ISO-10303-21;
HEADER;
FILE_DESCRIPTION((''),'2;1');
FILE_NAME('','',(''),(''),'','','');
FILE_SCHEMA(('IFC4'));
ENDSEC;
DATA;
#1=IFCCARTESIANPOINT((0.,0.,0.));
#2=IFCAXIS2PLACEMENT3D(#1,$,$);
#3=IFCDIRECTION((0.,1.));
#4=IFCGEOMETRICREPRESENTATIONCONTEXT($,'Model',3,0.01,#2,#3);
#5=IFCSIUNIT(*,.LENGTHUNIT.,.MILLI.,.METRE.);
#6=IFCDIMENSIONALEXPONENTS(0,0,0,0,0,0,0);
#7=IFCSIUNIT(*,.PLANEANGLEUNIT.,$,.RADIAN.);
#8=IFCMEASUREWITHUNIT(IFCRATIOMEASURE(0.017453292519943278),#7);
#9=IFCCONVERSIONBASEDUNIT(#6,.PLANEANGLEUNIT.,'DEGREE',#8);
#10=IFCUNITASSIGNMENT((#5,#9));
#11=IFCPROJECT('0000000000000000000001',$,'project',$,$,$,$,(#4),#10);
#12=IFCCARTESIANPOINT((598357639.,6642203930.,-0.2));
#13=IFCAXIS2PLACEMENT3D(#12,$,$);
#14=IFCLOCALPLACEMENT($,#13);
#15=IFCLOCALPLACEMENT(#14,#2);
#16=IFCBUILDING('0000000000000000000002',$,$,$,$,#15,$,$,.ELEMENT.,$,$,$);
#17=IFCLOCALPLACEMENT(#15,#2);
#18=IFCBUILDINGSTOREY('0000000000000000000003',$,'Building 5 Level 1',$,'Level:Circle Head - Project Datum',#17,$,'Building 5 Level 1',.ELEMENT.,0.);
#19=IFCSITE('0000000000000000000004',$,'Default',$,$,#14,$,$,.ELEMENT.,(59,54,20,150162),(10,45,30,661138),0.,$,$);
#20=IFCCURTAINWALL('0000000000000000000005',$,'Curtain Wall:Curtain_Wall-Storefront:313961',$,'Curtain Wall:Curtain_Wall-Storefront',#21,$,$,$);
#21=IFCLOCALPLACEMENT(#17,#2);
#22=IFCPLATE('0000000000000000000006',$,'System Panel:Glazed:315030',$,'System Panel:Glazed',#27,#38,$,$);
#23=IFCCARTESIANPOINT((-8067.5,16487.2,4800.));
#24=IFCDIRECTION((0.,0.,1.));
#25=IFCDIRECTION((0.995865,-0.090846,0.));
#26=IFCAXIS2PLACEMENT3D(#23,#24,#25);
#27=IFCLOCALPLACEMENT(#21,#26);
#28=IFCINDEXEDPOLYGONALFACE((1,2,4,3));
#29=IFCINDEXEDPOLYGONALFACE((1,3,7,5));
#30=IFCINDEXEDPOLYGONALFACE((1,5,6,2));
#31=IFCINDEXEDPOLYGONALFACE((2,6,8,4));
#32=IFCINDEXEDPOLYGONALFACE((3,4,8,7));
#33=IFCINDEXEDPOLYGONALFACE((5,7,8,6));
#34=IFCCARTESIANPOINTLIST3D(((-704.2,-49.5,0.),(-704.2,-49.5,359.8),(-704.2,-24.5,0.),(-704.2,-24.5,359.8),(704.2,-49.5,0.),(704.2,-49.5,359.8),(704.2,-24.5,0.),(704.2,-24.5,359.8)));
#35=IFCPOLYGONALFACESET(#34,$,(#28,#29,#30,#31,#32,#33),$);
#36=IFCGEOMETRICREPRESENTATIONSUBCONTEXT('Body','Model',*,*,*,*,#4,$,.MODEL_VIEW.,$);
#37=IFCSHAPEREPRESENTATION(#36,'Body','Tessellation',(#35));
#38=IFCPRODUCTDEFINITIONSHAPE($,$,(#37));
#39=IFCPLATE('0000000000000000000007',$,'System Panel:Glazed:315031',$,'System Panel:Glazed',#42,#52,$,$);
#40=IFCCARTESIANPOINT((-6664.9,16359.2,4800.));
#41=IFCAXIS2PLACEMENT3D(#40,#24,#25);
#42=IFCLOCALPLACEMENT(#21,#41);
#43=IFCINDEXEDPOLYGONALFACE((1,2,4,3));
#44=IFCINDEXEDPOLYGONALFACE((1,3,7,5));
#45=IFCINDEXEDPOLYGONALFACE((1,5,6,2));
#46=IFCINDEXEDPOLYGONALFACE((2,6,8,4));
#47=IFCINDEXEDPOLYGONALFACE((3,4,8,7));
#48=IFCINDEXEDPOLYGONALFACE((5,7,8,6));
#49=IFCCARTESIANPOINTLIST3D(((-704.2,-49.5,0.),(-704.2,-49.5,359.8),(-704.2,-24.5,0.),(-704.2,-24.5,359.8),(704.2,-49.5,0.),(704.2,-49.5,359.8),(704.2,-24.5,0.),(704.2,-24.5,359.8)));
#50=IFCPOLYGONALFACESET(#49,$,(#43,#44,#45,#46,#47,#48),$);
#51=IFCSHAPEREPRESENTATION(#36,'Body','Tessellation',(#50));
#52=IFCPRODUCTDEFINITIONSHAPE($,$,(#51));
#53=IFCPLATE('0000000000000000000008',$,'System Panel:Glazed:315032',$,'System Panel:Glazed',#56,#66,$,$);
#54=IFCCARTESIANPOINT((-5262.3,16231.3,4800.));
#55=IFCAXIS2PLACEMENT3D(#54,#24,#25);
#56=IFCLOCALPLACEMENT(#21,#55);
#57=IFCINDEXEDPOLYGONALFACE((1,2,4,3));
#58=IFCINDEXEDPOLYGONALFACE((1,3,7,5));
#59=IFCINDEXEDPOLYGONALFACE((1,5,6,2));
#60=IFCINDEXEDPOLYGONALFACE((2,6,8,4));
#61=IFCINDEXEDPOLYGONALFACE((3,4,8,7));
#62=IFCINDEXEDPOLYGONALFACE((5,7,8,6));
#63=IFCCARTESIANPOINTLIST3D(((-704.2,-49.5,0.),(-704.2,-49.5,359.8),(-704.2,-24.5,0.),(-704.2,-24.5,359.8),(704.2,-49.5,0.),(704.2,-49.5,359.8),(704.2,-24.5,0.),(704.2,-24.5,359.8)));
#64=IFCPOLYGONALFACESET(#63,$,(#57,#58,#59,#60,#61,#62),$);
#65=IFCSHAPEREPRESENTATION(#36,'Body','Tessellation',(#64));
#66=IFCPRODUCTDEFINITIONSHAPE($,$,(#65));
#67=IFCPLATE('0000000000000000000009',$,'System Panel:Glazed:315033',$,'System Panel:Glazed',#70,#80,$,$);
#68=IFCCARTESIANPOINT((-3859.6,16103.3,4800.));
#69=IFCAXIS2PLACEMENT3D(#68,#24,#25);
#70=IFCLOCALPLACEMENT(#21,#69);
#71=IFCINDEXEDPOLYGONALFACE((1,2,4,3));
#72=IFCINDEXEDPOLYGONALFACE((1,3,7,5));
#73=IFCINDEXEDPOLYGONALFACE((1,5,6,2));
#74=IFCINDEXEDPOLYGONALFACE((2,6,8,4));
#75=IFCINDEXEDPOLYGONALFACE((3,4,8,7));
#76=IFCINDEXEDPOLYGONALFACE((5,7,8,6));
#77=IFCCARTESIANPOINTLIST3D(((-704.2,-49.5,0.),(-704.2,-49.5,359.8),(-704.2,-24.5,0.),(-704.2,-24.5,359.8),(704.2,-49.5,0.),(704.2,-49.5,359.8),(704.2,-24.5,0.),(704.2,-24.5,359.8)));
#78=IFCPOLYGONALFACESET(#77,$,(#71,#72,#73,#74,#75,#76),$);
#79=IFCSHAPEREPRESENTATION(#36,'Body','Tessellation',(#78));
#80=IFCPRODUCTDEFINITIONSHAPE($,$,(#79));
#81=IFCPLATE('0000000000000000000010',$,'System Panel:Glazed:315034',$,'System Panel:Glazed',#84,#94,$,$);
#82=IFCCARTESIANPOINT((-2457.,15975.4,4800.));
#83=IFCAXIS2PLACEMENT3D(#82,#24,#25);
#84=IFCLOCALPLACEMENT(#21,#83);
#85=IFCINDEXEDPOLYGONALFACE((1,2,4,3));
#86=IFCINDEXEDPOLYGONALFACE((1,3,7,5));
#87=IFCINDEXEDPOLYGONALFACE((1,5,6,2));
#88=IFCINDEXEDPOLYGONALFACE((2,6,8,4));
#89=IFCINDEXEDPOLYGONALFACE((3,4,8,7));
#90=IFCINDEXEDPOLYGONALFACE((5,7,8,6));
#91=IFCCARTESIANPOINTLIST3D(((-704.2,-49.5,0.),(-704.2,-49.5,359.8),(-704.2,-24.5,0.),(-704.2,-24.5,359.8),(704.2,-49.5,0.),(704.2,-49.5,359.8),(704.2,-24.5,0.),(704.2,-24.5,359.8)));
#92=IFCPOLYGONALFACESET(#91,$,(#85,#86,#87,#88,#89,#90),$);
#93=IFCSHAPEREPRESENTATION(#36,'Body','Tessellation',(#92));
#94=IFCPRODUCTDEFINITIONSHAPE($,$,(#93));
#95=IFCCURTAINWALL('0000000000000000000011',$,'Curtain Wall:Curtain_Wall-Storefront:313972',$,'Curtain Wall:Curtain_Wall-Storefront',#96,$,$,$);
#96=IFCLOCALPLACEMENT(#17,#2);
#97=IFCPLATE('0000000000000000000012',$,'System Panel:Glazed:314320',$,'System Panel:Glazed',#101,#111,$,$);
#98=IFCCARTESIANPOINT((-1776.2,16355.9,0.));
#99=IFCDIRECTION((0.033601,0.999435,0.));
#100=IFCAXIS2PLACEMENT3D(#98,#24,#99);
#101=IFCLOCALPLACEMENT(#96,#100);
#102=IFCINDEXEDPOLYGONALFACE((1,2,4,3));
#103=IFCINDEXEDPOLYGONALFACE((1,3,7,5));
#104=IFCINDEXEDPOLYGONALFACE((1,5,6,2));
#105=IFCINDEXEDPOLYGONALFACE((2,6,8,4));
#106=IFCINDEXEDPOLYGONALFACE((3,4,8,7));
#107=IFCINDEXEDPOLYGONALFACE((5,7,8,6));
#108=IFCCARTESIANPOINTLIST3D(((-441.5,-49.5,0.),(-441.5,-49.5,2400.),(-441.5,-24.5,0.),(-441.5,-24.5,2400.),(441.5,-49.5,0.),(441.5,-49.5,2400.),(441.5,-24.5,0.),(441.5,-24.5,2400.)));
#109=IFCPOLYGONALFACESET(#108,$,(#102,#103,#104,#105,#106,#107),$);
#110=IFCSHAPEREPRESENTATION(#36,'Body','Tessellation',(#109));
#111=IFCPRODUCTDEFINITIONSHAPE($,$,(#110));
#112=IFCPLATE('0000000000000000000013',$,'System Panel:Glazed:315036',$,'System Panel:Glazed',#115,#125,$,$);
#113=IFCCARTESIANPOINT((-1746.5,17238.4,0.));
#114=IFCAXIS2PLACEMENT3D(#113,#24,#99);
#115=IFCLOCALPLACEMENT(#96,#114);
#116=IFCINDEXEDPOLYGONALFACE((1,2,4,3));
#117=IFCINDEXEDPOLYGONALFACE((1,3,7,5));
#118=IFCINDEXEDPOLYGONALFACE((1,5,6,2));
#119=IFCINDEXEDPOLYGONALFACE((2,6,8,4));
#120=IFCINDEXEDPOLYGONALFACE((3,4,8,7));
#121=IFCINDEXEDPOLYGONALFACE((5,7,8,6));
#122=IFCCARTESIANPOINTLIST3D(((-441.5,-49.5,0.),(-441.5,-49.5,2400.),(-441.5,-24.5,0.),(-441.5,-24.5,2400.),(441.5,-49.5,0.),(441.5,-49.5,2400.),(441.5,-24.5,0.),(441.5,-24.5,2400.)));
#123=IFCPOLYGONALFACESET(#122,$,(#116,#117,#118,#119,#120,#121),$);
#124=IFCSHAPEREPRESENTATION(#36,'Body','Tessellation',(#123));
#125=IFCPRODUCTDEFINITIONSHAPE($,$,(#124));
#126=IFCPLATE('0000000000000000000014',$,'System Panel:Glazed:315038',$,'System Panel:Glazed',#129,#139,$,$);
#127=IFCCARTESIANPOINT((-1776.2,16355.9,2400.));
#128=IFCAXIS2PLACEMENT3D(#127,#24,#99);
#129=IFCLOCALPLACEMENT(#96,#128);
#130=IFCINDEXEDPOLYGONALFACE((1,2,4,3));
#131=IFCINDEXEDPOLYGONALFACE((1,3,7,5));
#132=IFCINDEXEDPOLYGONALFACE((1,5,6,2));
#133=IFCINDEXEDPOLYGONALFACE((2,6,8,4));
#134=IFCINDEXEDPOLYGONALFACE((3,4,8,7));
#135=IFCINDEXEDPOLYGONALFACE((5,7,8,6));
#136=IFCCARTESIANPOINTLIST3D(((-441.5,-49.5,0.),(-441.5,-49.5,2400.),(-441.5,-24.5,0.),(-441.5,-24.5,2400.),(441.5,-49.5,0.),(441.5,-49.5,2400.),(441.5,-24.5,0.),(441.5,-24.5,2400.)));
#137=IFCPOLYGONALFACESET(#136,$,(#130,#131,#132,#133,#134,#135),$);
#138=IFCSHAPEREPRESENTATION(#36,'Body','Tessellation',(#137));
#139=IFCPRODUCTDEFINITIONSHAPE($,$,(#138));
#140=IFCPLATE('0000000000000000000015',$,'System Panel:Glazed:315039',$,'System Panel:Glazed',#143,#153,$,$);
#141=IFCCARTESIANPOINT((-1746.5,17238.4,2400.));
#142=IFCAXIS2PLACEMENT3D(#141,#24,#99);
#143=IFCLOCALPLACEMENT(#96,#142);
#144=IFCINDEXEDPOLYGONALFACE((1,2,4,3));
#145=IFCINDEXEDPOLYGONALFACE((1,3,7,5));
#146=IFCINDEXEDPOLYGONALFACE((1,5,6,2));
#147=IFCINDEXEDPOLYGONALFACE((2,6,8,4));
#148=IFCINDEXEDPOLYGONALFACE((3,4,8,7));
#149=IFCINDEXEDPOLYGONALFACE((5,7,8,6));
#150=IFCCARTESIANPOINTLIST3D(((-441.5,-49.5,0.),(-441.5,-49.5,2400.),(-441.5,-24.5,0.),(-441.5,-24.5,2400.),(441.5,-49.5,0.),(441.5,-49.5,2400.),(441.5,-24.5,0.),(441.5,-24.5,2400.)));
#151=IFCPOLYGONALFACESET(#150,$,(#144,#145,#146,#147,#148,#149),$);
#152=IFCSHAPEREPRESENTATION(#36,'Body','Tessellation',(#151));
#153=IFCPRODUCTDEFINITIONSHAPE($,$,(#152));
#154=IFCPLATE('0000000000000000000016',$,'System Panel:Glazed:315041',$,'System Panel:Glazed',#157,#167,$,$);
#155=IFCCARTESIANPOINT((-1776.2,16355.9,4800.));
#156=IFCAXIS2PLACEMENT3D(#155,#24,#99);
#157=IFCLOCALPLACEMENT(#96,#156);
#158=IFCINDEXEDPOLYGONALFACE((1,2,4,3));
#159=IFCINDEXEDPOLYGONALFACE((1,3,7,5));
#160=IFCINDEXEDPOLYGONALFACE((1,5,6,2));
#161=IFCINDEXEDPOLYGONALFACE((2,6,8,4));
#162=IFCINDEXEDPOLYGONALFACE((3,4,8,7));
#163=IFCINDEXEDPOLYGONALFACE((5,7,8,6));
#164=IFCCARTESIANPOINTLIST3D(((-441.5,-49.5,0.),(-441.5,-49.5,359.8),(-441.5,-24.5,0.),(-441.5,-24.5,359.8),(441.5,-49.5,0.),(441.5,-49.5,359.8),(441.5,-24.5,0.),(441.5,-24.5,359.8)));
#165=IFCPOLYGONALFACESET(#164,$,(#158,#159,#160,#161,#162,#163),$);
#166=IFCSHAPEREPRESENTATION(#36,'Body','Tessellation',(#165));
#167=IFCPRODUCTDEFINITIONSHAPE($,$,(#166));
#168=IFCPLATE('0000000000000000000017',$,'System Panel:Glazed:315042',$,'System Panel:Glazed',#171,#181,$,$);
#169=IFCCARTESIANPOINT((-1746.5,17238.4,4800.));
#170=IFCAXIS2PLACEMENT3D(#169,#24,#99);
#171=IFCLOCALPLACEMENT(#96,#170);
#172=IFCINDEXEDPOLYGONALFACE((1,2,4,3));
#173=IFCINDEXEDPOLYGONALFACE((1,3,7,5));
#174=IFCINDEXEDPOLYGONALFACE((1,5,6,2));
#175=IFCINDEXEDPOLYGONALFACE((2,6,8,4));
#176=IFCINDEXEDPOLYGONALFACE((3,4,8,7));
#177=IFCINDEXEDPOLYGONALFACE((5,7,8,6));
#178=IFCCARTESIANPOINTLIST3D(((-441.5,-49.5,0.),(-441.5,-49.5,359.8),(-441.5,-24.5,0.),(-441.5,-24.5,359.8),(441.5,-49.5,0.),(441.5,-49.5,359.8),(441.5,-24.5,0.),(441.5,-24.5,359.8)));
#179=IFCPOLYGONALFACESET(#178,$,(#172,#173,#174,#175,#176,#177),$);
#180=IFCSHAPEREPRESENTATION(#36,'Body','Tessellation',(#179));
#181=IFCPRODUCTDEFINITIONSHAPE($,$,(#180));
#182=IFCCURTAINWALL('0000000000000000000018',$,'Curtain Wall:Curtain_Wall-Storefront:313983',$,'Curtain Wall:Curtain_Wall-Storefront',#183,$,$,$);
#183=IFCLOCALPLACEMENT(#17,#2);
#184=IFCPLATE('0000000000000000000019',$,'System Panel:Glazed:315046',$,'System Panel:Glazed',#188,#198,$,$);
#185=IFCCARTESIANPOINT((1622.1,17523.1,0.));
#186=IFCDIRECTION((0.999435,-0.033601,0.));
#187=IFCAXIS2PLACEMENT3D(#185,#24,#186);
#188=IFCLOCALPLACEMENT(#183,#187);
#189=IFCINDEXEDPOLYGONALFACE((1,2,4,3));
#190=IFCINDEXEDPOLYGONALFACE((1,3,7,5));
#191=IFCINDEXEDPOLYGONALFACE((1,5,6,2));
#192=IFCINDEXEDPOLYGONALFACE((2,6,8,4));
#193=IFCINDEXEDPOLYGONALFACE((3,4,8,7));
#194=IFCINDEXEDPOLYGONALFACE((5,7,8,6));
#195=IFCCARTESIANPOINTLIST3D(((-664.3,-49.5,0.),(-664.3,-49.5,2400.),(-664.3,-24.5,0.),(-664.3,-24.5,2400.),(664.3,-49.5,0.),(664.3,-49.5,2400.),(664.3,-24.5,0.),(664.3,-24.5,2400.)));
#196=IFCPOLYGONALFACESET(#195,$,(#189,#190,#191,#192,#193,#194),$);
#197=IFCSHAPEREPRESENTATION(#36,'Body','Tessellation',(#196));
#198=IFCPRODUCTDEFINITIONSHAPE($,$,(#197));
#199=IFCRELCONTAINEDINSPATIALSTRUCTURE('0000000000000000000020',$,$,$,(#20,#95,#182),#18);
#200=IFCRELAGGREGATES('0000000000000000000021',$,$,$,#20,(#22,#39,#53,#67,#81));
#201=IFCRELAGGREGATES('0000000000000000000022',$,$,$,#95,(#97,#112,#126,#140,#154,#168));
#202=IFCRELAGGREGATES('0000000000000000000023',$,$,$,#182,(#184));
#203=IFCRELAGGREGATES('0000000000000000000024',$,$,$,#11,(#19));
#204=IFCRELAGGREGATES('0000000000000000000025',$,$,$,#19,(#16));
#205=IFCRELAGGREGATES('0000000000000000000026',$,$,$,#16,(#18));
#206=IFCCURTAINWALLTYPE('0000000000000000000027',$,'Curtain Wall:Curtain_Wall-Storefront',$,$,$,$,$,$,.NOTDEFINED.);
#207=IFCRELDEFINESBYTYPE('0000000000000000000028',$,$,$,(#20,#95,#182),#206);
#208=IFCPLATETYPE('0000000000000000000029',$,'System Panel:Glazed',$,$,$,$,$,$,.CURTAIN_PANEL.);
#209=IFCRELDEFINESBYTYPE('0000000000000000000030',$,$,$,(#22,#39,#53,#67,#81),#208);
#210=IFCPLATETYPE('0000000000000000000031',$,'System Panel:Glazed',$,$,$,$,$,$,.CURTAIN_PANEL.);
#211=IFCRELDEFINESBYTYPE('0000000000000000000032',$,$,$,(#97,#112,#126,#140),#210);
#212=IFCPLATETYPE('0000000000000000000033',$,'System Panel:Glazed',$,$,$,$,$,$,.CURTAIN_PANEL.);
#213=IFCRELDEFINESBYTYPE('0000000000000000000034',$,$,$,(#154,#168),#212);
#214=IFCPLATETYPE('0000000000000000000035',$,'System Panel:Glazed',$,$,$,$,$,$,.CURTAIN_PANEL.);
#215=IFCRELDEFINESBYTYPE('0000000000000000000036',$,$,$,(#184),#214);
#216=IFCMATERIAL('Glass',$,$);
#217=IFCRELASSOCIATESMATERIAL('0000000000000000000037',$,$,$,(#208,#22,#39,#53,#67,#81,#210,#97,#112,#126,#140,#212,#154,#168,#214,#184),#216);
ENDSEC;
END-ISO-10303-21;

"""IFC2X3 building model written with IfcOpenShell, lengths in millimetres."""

from ifc_helpers import new_model, entity, si_unit, converted_unit, direction, frame, frame_2d, origin, place, context, subcontext, project, spatial, rectangle, extrude, source, transform, mapped, material, type_object, type_shapes, element, aggregate, save


model = new_model("IFC2X3")

# Units and contexts
model_context = context("Model", 3, precision=0.01, world=origin(), true_north=direction((0.0, 1.0)))
body_context = subcontext(model_context, "Body", "Model", "MODEL_VIEW")
ifc_project = project(units=[si_unit("LENGTHUNIT", "METRE", prefix="MILLI"), converted_unit("PLANEANGLEUNIT", "DEGREE", entity("IfcRatioMeasure", 0.017453292519943278), si_unit("PLANEANGLEUNIT", "RADIAN"), dimensions=[0, 0, 0, 0, 0, 0, 0])], contexts=[model_context])

# Site, building, storey
site_placement = place(None, frame((598357639.0, 6642203930.0, -0.2)))
site = spatial("IfcSite", under=ifc_project, at=site_placement, Name="Default", CompositionType="ELEMENT", RefLatitude=(59, 54, 20, 150162), RefLongitude=(10, 45, 30, 661138), RefElevation=0.0)
building_placement = place(site_placement, origin())
building = spatial("IfcBuilding", under=site, at=building_placement, CompositionType="ELEMENT")
storey_placement = place(building_placement, origin())
storey = spatial("IfcBuildingStorey", under=building, at=storey_placement, Name="Building 5 Level 1", ObjectType="Level:Circle Head - Project Datum", LongName="Building 5 Level 1", CompositionType="ELEMENT", Elevation=0.0)

# Curtain walls, plates
curtain_wall_type = type_object("IfcCurtainWallType", Name="Curtain Wall:Curtain_Wall-Storefront", PredefinedType="NOTDEFINED")
ifc_material_1 = material(Name="Glass")
curtain_wall_1_placement = place(storey_placement, origin())
curtain_wall_1 = element("IfcCurtainWall", 1, at=curtain_wall_1_placement, inside=storey, type_object=curtain_wall_type, Name="Curtain Wall:Curtain_Wall-Storefront:313961", ObjectType="Curtain Wall:Curtain_Wall-Storefront")
plate_type_1 = type_object("IfcPlateType", Name="System Panel:Glazed", PredefinedType="CURTAIN_PANEL", material=ifc_material_1)
shared_shape_1 = source(origin(), body_context, "Body", "SweptSolid", [
    extrude(rectangle(XDim=25.0, YDim=1408.5, at=frame_2d((0.0, 0.0), x_axis=(1.0, 0.0))), frame((0.0, -37.0, 0.0), z_axis=(0.0, 0.0, 1.0), x_axis=(0.0, 1.0, 0.0)), (0.0, 0.0, 1.0), 359.8),
])
type_shapes(plate_type_1, [shared_shape_1])
plate_1_placement = place(curtain_wall_1_placement, frame((-8067.5, 16487.2, 4800.0), z_axis=(0.0, 0.0, 1.0), x_axis=(0.995865, -0.090846, 0.0)))
plate_1 = element("IfcPlate", 2, at=plate_1_placement, type_object=plate_type_1, material=ifc_material_1, Name="System Panel:Glazed:315030", ObjectType="System Panel:Glazed", context=body_context, shape_type="MappedRepresentation", body=[
    mapped(shared_shape_1, transform((0.0, 0.0, 0.0), scale=1.0)),
])
plate_2_placement = place(curtain_wall_1_placement, frame((-6664.9, 16359.2, 4800.0), z_axis=(0.0, 0.0, 1.0), x_axis=(0.995865, -0.090846, 0.0)))
plate_2 = element("IfcPlate", 3, at=plate_2_placement, type_object=plate_type_1, material=ifc_material_1, Name="System Panel:Glazed:315031", ObjectType="System Panel:Glazed", context=body_context, shape_type="MappedRepresentation", body=[
    mapped(shared_shape_1, transform((0.0, 0.0, 0.0), scale=1.0)),
])
plate_3_placement = place(curtain_wall_1_placement, frame((-5262.3, 16231.3, 4800.0), z_axis=(0.0, 0.0, 1.0), x_axis=(0.995865, -0.090846, 0.0)))
plate_3 = element("IfcPlate", 4, at=plate_3_placement, type_object=plate_type_1, material=ifc_material_1, Name="System Panel:Glazed:315032", ObjectType="System Panel:Glazed", context=body_context, shape_type="MappedRepresentation", body=[
    mapped(shared_shape_1, transform((0.0, 0.0, 0.0), scale=1.0)),
])
plate_4_placement = place(curtain_wall_1_placement, frame((-3859.6, 16103.3, 4800.0), z_axis=(0.0, 0.0, 1.0), x_axis=(0.995865, -0.090846, 0.0)))
plate_4 = element("IfcPlate", 5, at=plate_4_placement, type_object=plate_type_1, material=ifc_material_1, Name="System Panel:Glazed:315033", ObjectType="System Panel:Glazed", context=body_context, shape_type="MappedRepresentation", body=[
    mapped(shared_shape_1, transform((0.0, 0.0, 0.0), scale=1.0)),
])
plate_5_placement = place(curtain_wall_1_placement, frame((-2457.0, 15975.4, 4800.0), z_axis=(0.0, 0.0, 1.0), x_axis=(0.995865, -0.090846, 0.0)))
plate_5 = element("IfcPlate", 6, at=plate_5_placement, type_object=plate_type_1, material=ifc_material_1, Name="System Panel:Glazed:315034", ObjectType="System Panel:Glazed", context=body_context, shape_type="MappedRepresentation", body=[
    mapped(shared_shape_1, transform((0.0, 0.0, 0.0), scale=1.0)),
])
aggregate(curtain_wall_1, [plate_1, plate_2, plate_3, plate_4, plate_5])
curtain_wall_2_placement = place(storey_placement, origin())
curtain_wall_2 = element("IfcCurtainWall", 7, at=curtain_wall_2_placement, inside=storey, type_object=curtain_wall_type, Name="Curtain Wall:Curtain_Wall-Storefront:313972", ObjectType="Curtain Wall:Curtain_Wall-Storefront")
plate_type_2 = type_object("IfcPlateType", Name="System Panel:Glazed", PredefinedType="CURTAIN_PANEL", material=ifc_material_1)
shared_shape_2 = source(origin(), body_context, "Body", "SweptSolid", [
    extrude(rectangle(XDim=25.0, YDim=883.0, at=frame_2d((0.0, 0.0), x_axis=(1.0, 0.0))), frame((0.0, -37.0, 0.0), z_axis=(0.0, 0.0, 1.0), x_axis=(0.0, 1.0, 0.0)), (0.0, 0.0, 1.0), 2400.0),
])
type_shapes(plate_type_2, [shared_shape_2])
plate_6_placement = place(curtain_wall_2_placement, frame((-1776.2, 16355.9, 0.0), z_axis=(0.0, 0.0, 1.0), x_axis=(0.033601, 0.999435, 0.0)))
plate_6 = element("IfcPlate", 8, at=plate_6_placement, type_object=plate_type_2, material=ifc_material_1, Name="System Panel:Glazed:314320", ObjectType="System Panel:Glazed", context=body_context, shape_type="MappedRepresentation", body=[
    mapped(shared_shape_2, transform((0.0, 0.0, 0.0), scale=1.0)),
])
plate_7_placement = place(curtain_wall_2_placement, frame((-1746.5, 17238.4, 0.0), z_axis=(0.0, 0.0, 1.0), x_axis=(0.033601, 0.999435, 0.0)))
plate_7 = element("IfcPlate", 9, at=plate_7_placement, type_object=plate_type_2, material=ifc_material_1, Name="System Panel:Glazed:315036", ObjectType="System Panel:Glazed", context=body_context, shape_type="MappedRepresentation", body=[
    mapped(shared_shape_2, transform((0.0, 0.0, 0.0), scale=1.0)),
])
plate_8_placement = place(curtain_wall_2_placement, frame((-1776.2, 16355.9, 2400.0), z_axis=(0.0, 0.0, 1.0), x_axis=(0.033601, 0.999435, 0.0)))
plate_8 = element("IfcPlate", 10, at=plate_8_placement, type_object=plate_type_2, material=ifc_material_1, Name="System Panel:Glazed:315038", ObjectType="System Panel:Glazed", context=body_context, shape_type="MappedRepresentation", body=[
    mapped(shared_shape_2, transform((0.0, 0.0, 0.0), scale=1.0)),
])
plate_9_placement = place(curtain_wall_2_placement, frame((-1746.5, 17238.4, 2400.0), z_axis=(0.0, 0.0, 1.0), x_axis=(0.033601, 0.999435, 0.0)))
plate_9 = element("IfcPlate", 11, at=plate_9_placement, type_object=plate_type_2, material=ifc_material_1, Name="System Panel:Glazed:315039", ObjectType="System Panel:Glazed", context=body_context, shape_type="MappedRepresentation", body=[
    mapped(shared_shape_2, transform((0.0, 0.0, 0.0), scale=1.0)),
])
plate_type_3 = type_object("IfcPlateType", Name="System Panel:Glazed", PredefinedType="CURTAIN_PANEL", material=ifc_material_1)
shared_shape_3 = source(origin(), body_context, "Body", "SweptSolid", [
    extrude(rectangle(XDim=25.0, YDim=883.0, at=frame_2d((0.0, 0.0), x_axis=(1.0, 0.0))), frame((0.0, -37.0, 0.0), z_axis=(0.0, 0.0, 1.0), x_axis=(0.0, 1.0, 0.0)), (0.0, 0.0, 1.0), 359.8),
])
type_shapes(plate_type_3, [shared_shape_3])
plate_10_placement = place(curtain_wall_2_placement, frame((-1776.2, 16355.9, 4800.0), z_axis=(0.0, 0.0, 1.0), x_axis=(0.033601, 0.999435, 0.0)))
plate_10 = element("IfcPlate", 12, at=plate_10_placement, type_object=plate_type_3, material=ifc_material_1, Name="System Panel:Glazed:315041", ObjectType="System Panel:Glazed", context=body_context, shape_type="MappedRepresentation", body=[
    mapped(shared_shape_3, transform((0.0, 0.0, 0.0), scale=1.0)),
])
plate_11_placement = place(curtain_wall_2_placement, frame((-1746.5, 17238.4, 4800.0), z_axis=(0.0, 0.0, 1.0), x_axis=(0.033601, 0.999435, 0.0)))
plate_11 = element("IfcPlate", 13, at=plate_11_placement, type_object=plate_type_3, material=ifc_material_1, Name="System Panel:Glazed:315042", ObjectType="System Panel:Glazed", context=body_context, shape_type="MappedRepresentation", body=[
    mapped(shared_shape_3, transform((0.0, 0.0, 0.0), scale=1.0)),
])
aggregate(curtain_wall_2, [plate_6, plate_7, plate_8, plate_9, plate_10, plate_11])
curtain_wall_3_placement = place(storey_placement, origin())
curtain_wall_3 = element("IfcCurtainWall", 14, at=curtain_wall_3_placement, inside=storey, type_object=curtain_wall_type, Name="Curtain Wall:Curtain_Wall-Storefront:313983", ObjectType="Curtain Wall:Curtain_Wall-Storefront")
plate_type_4 = type_object("IfcPlateType", Name="System Panel:Glazed", PredefinedType="CURTAIN_PANEL", material=ifc_material_1)
shared_shape_4 = source(origin(), body_context, "Body", "SweptSolid", [
    extrude(rectangle(XDim=25.0, YDim=1328.6, at=frame_2d((0.0, 0.0), x_axis=(1.0, 0.0))), frame((0.0, -37.0, 0.0), z_axis=(0.0, 0.0, 1.0), x_axis=(0.0, 1.0, 0.0)), (0.0, 0.0, 1.0), 2400.0),
])
type_shapes(plate_type_4, [shared_shape_4])
plate_12_placement = place(curtain_wall_3_placement, frame((1622.1, 17523.1, 0.0), z_axis=(0.0, 0.0, 1.0), x_axis=(0.999435, -0.033601, 0.0)))
plate_12 = element("IfcPlate", 15, at=plate_12_placement, type_object=plate_type_4, material=ifc_material_1, Name="System Panel:Glazed:315046", ObjectType="System Panel:Glazed", context=body_context, shape_type="MappedRepresentation", body=[
    mapped(shared_shape_4, transform((0.0, 0.0, 0.0), scale=1.0)),
])
aggregate(curtain_wall_3, [plate_12])

save(model, "model.ifc")
